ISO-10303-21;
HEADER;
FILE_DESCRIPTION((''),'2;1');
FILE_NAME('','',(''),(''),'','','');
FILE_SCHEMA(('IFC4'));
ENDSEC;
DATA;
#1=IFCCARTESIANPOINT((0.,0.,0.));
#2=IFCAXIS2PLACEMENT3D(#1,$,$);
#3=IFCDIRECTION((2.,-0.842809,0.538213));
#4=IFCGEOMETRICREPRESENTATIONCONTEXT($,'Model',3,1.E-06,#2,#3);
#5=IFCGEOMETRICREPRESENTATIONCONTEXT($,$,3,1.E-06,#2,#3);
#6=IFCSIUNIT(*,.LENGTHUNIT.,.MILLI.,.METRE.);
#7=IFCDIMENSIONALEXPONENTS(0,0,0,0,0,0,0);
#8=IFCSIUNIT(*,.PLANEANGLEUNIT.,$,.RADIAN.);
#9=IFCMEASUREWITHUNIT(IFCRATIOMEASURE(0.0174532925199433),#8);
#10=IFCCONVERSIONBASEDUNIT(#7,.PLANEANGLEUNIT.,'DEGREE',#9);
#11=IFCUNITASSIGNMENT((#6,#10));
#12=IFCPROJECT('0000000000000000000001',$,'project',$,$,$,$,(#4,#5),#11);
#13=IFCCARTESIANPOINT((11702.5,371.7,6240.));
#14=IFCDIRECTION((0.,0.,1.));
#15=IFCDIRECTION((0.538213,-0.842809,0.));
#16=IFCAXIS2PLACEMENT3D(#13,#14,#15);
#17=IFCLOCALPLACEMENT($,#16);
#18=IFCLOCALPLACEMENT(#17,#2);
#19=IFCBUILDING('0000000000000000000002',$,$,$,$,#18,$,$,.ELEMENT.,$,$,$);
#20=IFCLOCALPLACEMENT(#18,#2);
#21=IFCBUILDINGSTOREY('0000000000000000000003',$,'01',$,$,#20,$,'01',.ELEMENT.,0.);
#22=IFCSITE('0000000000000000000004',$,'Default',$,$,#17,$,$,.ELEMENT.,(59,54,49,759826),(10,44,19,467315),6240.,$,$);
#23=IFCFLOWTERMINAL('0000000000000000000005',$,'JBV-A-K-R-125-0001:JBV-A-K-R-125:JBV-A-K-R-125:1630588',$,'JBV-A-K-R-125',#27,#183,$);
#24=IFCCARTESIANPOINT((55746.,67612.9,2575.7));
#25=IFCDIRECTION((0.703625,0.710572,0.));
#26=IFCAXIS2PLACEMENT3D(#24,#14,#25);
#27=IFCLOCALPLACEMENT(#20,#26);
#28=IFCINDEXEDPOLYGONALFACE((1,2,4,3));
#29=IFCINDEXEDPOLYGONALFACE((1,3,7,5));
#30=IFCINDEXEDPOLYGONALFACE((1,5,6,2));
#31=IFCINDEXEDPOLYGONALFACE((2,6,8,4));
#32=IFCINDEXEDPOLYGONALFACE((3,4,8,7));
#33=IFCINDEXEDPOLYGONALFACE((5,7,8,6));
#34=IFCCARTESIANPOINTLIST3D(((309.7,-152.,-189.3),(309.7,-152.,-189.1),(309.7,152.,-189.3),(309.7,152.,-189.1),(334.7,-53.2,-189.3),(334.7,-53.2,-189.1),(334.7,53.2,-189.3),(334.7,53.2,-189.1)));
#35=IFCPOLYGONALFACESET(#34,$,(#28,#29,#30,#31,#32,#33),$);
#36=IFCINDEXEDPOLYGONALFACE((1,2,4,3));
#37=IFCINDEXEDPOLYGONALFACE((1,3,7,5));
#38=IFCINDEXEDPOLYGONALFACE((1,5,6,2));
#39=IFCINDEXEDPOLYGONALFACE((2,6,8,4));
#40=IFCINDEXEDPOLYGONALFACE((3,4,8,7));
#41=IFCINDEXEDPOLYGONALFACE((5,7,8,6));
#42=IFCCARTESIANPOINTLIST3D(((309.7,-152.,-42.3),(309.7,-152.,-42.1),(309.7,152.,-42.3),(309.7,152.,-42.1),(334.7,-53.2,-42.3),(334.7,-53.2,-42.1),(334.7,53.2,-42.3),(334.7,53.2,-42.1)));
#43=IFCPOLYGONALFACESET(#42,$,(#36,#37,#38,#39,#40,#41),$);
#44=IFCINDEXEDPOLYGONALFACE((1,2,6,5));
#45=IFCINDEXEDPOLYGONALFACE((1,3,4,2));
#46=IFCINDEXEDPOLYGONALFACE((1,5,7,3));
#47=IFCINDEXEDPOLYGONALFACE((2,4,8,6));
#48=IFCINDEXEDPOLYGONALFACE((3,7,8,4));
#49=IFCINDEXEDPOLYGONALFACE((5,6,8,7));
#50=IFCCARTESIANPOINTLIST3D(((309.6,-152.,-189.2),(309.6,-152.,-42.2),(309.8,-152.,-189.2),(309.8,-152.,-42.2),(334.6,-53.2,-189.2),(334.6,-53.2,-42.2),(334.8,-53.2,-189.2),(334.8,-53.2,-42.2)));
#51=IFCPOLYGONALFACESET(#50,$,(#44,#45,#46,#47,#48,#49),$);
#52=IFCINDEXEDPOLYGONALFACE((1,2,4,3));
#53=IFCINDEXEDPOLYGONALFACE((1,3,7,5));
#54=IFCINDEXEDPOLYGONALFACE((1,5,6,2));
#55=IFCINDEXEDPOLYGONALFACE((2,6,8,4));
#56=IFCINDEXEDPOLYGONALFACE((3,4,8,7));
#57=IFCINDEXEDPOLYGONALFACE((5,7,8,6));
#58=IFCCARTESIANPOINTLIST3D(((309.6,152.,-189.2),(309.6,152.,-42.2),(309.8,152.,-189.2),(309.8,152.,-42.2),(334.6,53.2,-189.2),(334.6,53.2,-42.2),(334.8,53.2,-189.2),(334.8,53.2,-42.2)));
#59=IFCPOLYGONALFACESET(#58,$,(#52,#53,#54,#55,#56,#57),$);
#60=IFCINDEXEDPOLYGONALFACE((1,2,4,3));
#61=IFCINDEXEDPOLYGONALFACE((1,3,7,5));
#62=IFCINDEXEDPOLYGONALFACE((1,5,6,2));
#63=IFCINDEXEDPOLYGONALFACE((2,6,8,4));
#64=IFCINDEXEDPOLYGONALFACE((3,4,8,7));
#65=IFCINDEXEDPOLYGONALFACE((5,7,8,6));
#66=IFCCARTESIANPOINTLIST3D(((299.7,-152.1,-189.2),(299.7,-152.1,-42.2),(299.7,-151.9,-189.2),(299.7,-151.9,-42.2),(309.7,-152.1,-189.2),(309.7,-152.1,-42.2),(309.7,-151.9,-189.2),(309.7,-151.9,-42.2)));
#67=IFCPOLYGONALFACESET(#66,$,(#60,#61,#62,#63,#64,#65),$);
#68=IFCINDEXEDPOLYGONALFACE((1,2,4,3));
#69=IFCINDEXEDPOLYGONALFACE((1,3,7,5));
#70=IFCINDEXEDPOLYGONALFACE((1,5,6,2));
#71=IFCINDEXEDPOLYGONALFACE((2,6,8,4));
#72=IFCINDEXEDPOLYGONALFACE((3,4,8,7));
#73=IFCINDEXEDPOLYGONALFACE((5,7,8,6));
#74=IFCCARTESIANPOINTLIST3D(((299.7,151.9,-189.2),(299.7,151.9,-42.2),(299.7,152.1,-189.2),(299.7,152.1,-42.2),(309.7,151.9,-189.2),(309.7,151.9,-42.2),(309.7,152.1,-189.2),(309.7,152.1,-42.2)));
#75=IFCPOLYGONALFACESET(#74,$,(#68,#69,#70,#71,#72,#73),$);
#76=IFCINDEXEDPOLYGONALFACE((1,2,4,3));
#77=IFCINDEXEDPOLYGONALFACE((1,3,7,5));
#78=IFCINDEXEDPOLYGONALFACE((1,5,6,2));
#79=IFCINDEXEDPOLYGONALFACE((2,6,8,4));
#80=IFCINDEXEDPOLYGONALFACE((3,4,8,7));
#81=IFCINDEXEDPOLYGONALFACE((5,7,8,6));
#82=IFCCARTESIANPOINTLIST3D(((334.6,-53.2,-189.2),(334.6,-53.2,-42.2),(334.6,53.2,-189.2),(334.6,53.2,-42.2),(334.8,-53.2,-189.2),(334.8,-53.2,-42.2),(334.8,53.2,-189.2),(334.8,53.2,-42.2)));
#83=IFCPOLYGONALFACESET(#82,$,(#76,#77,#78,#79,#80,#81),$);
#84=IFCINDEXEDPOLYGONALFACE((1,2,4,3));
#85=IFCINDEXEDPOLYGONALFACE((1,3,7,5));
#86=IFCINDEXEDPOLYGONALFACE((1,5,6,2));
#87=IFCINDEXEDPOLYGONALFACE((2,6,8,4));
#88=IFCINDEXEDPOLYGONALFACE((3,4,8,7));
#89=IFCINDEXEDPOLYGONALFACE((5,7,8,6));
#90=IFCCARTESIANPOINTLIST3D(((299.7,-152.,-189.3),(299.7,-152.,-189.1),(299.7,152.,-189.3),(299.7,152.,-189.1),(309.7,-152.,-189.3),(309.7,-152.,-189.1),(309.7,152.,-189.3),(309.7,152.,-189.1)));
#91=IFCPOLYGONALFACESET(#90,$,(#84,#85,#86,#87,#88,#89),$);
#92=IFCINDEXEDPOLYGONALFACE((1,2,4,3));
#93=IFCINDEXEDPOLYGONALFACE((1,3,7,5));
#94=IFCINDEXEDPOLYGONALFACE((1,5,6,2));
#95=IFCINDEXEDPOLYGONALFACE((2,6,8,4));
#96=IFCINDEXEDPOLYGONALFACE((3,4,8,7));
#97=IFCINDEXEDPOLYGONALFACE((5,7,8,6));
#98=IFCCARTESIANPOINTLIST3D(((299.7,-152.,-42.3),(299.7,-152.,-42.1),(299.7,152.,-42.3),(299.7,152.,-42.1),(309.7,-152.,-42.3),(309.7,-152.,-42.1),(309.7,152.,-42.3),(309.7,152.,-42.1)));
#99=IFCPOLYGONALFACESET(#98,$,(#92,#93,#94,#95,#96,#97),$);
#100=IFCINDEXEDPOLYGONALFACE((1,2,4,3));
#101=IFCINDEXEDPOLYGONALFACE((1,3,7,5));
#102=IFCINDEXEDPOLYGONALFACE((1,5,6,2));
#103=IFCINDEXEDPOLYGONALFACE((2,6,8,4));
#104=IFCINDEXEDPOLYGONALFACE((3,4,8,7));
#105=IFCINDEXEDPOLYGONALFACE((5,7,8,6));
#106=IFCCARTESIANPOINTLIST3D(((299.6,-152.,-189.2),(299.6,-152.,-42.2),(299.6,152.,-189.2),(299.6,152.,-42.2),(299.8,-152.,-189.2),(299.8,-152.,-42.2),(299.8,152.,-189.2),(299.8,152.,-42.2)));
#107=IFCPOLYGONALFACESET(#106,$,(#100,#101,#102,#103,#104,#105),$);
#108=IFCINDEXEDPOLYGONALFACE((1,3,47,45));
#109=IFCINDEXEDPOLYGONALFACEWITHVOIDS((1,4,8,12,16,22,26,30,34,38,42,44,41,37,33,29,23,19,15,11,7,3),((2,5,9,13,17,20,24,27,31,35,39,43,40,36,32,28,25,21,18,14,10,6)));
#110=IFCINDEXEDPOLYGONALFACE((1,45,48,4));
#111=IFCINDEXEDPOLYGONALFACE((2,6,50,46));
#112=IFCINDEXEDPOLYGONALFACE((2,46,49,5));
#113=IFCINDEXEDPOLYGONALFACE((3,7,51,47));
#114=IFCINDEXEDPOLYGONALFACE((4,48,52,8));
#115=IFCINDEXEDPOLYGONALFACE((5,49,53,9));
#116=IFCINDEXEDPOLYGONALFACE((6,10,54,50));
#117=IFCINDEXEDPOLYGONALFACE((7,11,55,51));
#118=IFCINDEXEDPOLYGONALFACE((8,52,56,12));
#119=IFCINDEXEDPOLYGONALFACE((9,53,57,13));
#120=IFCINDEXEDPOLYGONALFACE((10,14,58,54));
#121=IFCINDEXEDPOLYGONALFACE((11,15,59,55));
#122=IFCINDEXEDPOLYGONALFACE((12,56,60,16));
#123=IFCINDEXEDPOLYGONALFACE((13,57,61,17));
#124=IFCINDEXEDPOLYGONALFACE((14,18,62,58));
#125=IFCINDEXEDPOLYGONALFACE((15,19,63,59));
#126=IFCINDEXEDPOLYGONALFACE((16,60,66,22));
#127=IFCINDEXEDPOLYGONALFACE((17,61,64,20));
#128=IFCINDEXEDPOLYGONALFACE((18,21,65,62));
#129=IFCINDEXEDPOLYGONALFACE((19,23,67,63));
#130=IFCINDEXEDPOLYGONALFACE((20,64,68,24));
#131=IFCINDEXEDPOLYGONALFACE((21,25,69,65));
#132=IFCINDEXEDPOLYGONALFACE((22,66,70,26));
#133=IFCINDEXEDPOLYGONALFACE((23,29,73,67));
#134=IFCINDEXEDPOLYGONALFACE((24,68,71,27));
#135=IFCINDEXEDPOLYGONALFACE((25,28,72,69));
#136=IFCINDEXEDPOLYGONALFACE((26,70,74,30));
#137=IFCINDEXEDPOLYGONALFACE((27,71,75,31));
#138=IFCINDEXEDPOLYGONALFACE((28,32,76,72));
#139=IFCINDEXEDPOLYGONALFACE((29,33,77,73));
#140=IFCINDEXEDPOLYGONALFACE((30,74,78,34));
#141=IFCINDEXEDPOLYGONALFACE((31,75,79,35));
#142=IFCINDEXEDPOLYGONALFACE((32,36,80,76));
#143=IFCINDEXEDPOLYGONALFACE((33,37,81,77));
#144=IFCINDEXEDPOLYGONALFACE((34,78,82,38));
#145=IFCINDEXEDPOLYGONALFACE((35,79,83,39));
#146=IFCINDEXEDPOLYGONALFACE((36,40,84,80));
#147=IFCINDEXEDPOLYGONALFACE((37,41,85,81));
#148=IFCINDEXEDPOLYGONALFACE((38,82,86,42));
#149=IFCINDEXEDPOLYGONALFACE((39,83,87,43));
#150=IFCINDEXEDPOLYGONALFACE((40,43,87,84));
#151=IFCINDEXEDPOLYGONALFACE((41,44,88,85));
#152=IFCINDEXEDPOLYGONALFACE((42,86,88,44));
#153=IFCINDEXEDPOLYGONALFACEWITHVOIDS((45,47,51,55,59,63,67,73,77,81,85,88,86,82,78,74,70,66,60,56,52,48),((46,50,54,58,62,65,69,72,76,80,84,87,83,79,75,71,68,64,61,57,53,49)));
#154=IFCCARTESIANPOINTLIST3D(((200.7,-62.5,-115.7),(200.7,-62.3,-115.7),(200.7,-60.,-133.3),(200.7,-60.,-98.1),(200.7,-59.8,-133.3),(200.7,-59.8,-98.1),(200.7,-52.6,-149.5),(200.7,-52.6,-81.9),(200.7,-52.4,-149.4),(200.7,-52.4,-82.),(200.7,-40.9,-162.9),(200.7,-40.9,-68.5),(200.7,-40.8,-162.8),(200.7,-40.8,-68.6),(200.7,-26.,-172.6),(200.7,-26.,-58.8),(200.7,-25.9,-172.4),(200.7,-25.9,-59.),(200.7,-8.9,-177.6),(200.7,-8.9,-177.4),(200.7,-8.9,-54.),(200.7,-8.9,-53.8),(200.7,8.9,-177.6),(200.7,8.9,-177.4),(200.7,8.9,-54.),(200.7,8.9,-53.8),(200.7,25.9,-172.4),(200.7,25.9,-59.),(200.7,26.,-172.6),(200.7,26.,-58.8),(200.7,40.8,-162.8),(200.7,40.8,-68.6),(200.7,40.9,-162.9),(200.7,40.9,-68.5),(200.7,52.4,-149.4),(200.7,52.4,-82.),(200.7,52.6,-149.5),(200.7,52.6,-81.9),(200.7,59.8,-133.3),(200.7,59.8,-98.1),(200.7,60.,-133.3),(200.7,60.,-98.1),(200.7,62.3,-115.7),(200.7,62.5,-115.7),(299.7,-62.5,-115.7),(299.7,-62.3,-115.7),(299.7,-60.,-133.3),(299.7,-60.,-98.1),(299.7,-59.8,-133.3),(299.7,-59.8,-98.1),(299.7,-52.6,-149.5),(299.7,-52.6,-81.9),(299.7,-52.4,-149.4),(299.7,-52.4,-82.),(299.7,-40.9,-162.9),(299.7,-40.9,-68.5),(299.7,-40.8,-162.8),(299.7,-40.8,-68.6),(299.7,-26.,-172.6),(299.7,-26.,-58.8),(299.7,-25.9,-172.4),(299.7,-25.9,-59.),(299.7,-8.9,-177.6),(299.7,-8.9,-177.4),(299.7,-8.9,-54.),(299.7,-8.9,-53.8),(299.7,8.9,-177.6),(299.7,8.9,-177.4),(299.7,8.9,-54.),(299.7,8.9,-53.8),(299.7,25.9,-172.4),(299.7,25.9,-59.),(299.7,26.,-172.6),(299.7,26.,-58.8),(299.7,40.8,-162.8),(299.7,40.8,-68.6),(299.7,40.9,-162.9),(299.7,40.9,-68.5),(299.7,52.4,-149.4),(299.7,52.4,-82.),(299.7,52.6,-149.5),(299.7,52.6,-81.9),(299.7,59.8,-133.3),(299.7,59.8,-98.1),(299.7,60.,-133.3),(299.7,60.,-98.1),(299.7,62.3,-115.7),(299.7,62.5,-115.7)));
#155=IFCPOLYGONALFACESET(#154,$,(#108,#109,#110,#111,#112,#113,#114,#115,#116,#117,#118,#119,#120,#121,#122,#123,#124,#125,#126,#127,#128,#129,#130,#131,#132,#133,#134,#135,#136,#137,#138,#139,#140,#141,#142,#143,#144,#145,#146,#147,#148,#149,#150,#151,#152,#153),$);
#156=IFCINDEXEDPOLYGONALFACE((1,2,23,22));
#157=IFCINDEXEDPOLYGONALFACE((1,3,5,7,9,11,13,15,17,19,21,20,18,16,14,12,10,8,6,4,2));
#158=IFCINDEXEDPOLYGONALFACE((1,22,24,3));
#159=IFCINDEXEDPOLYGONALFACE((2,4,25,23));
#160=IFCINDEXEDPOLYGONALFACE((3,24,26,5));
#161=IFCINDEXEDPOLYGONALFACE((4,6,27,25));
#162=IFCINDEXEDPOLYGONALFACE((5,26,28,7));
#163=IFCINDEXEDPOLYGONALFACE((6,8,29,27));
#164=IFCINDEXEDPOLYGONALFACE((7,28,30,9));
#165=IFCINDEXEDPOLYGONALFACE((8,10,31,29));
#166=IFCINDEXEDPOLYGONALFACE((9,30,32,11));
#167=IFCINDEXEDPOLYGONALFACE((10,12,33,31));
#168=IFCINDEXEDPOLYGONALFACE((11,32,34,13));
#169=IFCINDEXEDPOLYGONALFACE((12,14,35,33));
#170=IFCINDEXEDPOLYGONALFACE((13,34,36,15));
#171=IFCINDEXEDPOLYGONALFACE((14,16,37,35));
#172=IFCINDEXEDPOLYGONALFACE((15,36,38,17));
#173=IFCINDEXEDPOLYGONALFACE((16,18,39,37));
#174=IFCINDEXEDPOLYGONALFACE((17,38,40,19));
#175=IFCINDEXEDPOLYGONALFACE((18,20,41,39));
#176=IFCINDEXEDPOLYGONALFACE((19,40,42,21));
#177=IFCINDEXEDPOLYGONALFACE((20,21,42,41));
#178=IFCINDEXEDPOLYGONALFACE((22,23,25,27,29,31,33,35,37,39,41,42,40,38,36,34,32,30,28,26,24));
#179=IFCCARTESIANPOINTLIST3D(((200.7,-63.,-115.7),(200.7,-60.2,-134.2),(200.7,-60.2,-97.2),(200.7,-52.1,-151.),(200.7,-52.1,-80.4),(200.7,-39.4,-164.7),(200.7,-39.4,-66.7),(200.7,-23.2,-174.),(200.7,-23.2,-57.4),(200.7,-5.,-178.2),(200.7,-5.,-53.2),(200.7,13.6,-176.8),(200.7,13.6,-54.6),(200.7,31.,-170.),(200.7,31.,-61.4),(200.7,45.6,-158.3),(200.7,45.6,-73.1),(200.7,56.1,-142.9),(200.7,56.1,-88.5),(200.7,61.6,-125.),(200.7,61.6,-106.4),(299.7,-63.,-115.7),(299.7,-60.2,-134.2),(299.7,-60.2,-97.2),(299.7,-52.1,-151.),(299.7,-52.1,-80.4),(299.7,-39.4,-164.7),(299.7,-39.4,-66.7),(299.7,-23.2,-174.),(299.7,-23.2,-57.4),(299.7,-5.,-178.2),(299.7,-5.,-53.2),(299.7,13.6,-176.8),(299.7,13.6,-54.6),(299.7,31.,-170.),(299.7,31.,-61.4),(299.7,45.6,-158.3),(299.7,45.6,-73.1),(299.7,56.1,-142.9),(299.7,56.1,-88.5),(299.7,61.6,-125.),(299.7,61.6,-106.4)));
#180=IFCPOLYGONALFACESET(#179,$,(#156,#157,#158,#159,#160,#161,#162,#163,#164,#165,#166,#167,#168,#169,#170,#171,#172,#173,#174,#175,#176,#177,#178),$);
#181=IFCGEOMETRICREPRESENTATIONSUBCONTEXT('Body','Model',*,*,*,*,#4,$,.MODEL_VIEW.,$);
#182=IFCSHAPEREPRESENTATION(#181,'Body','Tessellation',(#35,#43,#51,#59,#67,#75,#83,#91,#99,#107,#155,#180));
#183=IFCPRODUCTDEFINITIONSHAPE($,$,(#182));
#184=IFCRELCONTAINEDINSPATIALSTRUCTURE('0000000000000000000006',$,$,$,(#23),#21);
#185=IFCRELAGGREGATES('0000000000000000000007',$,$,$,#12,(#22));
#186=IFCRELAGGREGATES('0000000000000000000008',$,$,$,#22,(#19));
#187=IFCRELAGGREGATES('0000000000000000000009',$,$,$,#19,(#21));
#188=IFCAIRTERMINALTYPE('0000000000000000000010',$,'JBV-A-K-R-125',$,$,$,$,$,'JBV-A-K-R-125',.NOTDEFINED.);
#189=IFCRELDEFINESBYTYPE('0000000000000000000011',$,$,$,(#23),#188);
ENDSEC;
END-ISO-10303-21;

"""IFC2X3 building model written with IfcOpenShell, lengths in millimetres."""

from ifc_helpers import new_model, entity, si_unit, converted_unit, direction, frame, frame_2d, origin, origin_2d_with_axis, place, context, subcontext, project, spatial, polyline, circle_curve, parameter, trimmed, segment, composite_curve, rectangle, circle, outline, extrude, source, transform, mapped, type_object, type_shapes, element, save


model = new_model("IFC2X3")

# Units and contexts
model_context = context("Model", 3, precision=1e-06, world=origin(), true_north=direction((2.0, -0.842809, 0.538213)))
context_of_model = context(None, 3, precision=1e-06, world=origin(), true_north=direction((2.0, -0.842809, 0.538213)))
body_context = subcontext(model_context, "Body", "Model", "MODEL_VIEW")
ifc_project = project(units=[si_unit("LENGTHUNIT", "METRE", prefix="MILLI"), converted_unit("PLANEANGLEUNIT", "DEGREE", entity("IfcRatioMeasure", 0.0174532925199433), si_unit("PLANEANGLEUNIT", "RADIAN"), dimensions=[0, 0, 0, 0, 0, 0, 0])], contexts=[model_context, context_of_model])

# Site, building, storey
site_placement = place(None, frame((11702.5, 371.7, 6240.0), z_axis=(0.0, 0.0, 1.0), x_axis=(0.538213, -0.842809, 0.0)))
site = spatial("IfcSite", under=ifc_project, at=site_placement, Name="Default", CompositionType="ELEMENT", RefLatitude=(59, 54, 49, 759826), RefLongitude=(10, 44, 19, 467315), RefElevation=6240.0)
building_placement = place(site_placement, origin())
building = spatial("IfcBuilding", under=site, at=building_placement, CompositionType="ELEMENT")
storey_placement = place(building_placement, origin())
storey = spatial("IfcBuildingStorey", under=building, at=storey_placement, Name="01", LongName="01", CompositionType="ELEMENT", Elevation=0.0)

# Flow terminal
air_terminal_type_1 = type_object("IfcAirTerminalType", Name="JBV-A-K-R-125", ElementType="JBV-A-K-R-125", PredefinedType="NOTDEFINED")
shared_shape_1 = source(origin(), body_context, "Body", "SweptSolid", [
    extrude(outline(polyline([(-150.4, -25.2), (-48.5, -25.2), (54.6, 0.9), (144.3, 49.4), (-150.4, -25.2)])), frame((322.2, 0.0, -189.3), z_axis=(0.0, 0.0, 1.0), x_axis=(0.245305, 0.969446, 0.0)), (0.0, 0.0, 1.0), 0.2),
    extrude(outline(polyline([(-150.4, -25.2), (-48.5, -25.2), (54.6, 0.9), (144.3, 49.4), (-150.4, -25.2)])), frame((322.2, 0.0, -42.3), z_axis=(0.0, 0.0, 1.0), x_axis=(0.245305, 0.969446, 0.0)), (0.0, 0.0, 1.0), 0.2),
    extrude(rectangle(XDim=101.9, YDim=0.2, at=frame_2d((0.0, 0.0), x_axis=(1.0, 0.0))), frame((322.2, -102.6, -189.2), z_axis=(0.0, 0.0, 1.0), x_axis=(-0.245305, -0.969446, 0.0)), (0.0, 0.0, 1.0), 147.0),
    extrude(rectangle(XDim=101.9, YDim=0.2, at=frame_2d((0.0, 0.0), x_axis=(1.0, 0.0))), frame((322.2, 102.6, -189.2), z_axis=(0.0, 0.0, 1.0), x_axis=(-0.245305, 0.969446, 0.0)), (0.0, 0.0, 1.0), 147.0),
    extrude(rectangle(XDim=10.0, YDim=0.2, at=frame_2d((0.0, 0.0), x_axis=(1.0, 0.0))), frame((304.7, -152.0, -189.2), z_axis=(0.0, 0.0, 1.0), x_axis=(-1.0, 0.0, 0.0)), (0.0, 0.0, 1.0), 147.0),
    extrude(rectangle(XDim=10.0, YDim=0.2, at=frame_2d((0.0, 0.0), x_axis=(1.0, 0.0))), frame((304.7, 152.0, -189.2), z_axis=(0.0, 0.0, 1.0), x_axis=(-1.0, 0.0, 0.0)), (0.0, 0.0, 1.0), 147.0),
    extrude(rectangle(XDim=106.4, YDim=0.2, at=frame_2d((0.0, 0.0), x_axis=(1.0, 0.0))), frame((334.7, 0.0, -189.2), z_axis=(0.0, 0.0, 1.0), x_axis=(0.0, -1.0, 0.0)), (0.0, 0.0, 1.0), 147.0),
    extrude(rectangle(XDim=10.0, YDim=304.0, at=frame_2d((0.0, 0.0), x_axis=(1.0, 0.0))), frame((304.7, 0.0, -189.3)), (0.0, 0.0, 1.0), 0.2),
    extrude(rectangle(XDim=10.0, YDim=304.0, at=frame_2d((0.0, 0.0), x_axis=(1.0, 0.0))), frame((304.7, 0.0, -42.3)), (0.0, 0.0, 1.0), 0.2),
    extrude(rectangle(XDim=304.0, YDim=0.2, at=frame_2d((0.0, 0.0), x_axis=(1.0, 0.0))), frame((299.7, 0.0, -189.2), z_axis=(0.0, 0.0, 1.0), x_axis=(0.0, -1.0, 0.0)), (0.0, 0.0, 1.0), 147.0),
    extrude(outline(composite_curve([segment(trimmed(circle_curve(origin_2d_with_axis(), 62.5), [parameter(0.0)], [parameter(180.0)], True, "PARAMETER"), True, "CONTINUOUS"), segment(trimmed(circle_curve(origin_2d_with_axis(), 62.5), [parameter(180.0)], [parameter(0.0)], True, "PARAMETER"), True, "CONTINUOUS")], self_intersect=False), holes=[composite_curve([segment(trimmed(circle_curve(origin_2d_with_axis(), 62.3), [parameter(180.0)], [parameter(360.0)], True, "PARAMETER"), False, "CONTINUOUS"), segment(trimmed(circle_curve(origin_2d_with_axis(), 62.3), [parameter(0.0)], [parameter(180.0)], True, "PARAMETER"), False, "CONTINUOUS")], self_intersect=False)]), frame((200.7, 0.0, -115.7), z_axis=(1.0, 0.0, 0.0), x_axis=(0.0, -1.0, 0.0)), (0.0, 0.0, 1.0), 99.0),
    extrude(circle(Radius=62.6, at=frame_2d((0.0, 0.0), x_axis=(1.0, 0.0))), frame((200.7, -0.3, -115.7), z_axis=(1.0, 0.0, 0.0), x_axis=(0.0, -1.0, 0.0)), (0.0, 0.0, 1.0), 99.0),
])
type_shapes(air_terminal_type_1, [shared_shape_1])
for number, where, z_axis, x_axis, name in (
    (1, (55746.0, 67612.9, 2575.7), (0.0, 0.0, 1.0), (0.703625, 0.710572, 0.0), "JBV-A-K-R-125-0001:JBV-A-K-R-125:JBV-A-K-R-125:1630588"),
):
    element("IfcFlowTerminal", number, at=place(storey_placement, frame(where, z_axis=z_axis, x_axis=x_axis)), inside=storey, type_object=air_terminal_type_1, Name=name, ObjectType="JBV-A-K-R-125", context=body_context, shape_type="MappedRepresentation", body=[
        mapped(shared_shape_1, transform((0.0, 0.0, 0.0), scale=1.0)),
    ])

save(model, "model.ifc")
